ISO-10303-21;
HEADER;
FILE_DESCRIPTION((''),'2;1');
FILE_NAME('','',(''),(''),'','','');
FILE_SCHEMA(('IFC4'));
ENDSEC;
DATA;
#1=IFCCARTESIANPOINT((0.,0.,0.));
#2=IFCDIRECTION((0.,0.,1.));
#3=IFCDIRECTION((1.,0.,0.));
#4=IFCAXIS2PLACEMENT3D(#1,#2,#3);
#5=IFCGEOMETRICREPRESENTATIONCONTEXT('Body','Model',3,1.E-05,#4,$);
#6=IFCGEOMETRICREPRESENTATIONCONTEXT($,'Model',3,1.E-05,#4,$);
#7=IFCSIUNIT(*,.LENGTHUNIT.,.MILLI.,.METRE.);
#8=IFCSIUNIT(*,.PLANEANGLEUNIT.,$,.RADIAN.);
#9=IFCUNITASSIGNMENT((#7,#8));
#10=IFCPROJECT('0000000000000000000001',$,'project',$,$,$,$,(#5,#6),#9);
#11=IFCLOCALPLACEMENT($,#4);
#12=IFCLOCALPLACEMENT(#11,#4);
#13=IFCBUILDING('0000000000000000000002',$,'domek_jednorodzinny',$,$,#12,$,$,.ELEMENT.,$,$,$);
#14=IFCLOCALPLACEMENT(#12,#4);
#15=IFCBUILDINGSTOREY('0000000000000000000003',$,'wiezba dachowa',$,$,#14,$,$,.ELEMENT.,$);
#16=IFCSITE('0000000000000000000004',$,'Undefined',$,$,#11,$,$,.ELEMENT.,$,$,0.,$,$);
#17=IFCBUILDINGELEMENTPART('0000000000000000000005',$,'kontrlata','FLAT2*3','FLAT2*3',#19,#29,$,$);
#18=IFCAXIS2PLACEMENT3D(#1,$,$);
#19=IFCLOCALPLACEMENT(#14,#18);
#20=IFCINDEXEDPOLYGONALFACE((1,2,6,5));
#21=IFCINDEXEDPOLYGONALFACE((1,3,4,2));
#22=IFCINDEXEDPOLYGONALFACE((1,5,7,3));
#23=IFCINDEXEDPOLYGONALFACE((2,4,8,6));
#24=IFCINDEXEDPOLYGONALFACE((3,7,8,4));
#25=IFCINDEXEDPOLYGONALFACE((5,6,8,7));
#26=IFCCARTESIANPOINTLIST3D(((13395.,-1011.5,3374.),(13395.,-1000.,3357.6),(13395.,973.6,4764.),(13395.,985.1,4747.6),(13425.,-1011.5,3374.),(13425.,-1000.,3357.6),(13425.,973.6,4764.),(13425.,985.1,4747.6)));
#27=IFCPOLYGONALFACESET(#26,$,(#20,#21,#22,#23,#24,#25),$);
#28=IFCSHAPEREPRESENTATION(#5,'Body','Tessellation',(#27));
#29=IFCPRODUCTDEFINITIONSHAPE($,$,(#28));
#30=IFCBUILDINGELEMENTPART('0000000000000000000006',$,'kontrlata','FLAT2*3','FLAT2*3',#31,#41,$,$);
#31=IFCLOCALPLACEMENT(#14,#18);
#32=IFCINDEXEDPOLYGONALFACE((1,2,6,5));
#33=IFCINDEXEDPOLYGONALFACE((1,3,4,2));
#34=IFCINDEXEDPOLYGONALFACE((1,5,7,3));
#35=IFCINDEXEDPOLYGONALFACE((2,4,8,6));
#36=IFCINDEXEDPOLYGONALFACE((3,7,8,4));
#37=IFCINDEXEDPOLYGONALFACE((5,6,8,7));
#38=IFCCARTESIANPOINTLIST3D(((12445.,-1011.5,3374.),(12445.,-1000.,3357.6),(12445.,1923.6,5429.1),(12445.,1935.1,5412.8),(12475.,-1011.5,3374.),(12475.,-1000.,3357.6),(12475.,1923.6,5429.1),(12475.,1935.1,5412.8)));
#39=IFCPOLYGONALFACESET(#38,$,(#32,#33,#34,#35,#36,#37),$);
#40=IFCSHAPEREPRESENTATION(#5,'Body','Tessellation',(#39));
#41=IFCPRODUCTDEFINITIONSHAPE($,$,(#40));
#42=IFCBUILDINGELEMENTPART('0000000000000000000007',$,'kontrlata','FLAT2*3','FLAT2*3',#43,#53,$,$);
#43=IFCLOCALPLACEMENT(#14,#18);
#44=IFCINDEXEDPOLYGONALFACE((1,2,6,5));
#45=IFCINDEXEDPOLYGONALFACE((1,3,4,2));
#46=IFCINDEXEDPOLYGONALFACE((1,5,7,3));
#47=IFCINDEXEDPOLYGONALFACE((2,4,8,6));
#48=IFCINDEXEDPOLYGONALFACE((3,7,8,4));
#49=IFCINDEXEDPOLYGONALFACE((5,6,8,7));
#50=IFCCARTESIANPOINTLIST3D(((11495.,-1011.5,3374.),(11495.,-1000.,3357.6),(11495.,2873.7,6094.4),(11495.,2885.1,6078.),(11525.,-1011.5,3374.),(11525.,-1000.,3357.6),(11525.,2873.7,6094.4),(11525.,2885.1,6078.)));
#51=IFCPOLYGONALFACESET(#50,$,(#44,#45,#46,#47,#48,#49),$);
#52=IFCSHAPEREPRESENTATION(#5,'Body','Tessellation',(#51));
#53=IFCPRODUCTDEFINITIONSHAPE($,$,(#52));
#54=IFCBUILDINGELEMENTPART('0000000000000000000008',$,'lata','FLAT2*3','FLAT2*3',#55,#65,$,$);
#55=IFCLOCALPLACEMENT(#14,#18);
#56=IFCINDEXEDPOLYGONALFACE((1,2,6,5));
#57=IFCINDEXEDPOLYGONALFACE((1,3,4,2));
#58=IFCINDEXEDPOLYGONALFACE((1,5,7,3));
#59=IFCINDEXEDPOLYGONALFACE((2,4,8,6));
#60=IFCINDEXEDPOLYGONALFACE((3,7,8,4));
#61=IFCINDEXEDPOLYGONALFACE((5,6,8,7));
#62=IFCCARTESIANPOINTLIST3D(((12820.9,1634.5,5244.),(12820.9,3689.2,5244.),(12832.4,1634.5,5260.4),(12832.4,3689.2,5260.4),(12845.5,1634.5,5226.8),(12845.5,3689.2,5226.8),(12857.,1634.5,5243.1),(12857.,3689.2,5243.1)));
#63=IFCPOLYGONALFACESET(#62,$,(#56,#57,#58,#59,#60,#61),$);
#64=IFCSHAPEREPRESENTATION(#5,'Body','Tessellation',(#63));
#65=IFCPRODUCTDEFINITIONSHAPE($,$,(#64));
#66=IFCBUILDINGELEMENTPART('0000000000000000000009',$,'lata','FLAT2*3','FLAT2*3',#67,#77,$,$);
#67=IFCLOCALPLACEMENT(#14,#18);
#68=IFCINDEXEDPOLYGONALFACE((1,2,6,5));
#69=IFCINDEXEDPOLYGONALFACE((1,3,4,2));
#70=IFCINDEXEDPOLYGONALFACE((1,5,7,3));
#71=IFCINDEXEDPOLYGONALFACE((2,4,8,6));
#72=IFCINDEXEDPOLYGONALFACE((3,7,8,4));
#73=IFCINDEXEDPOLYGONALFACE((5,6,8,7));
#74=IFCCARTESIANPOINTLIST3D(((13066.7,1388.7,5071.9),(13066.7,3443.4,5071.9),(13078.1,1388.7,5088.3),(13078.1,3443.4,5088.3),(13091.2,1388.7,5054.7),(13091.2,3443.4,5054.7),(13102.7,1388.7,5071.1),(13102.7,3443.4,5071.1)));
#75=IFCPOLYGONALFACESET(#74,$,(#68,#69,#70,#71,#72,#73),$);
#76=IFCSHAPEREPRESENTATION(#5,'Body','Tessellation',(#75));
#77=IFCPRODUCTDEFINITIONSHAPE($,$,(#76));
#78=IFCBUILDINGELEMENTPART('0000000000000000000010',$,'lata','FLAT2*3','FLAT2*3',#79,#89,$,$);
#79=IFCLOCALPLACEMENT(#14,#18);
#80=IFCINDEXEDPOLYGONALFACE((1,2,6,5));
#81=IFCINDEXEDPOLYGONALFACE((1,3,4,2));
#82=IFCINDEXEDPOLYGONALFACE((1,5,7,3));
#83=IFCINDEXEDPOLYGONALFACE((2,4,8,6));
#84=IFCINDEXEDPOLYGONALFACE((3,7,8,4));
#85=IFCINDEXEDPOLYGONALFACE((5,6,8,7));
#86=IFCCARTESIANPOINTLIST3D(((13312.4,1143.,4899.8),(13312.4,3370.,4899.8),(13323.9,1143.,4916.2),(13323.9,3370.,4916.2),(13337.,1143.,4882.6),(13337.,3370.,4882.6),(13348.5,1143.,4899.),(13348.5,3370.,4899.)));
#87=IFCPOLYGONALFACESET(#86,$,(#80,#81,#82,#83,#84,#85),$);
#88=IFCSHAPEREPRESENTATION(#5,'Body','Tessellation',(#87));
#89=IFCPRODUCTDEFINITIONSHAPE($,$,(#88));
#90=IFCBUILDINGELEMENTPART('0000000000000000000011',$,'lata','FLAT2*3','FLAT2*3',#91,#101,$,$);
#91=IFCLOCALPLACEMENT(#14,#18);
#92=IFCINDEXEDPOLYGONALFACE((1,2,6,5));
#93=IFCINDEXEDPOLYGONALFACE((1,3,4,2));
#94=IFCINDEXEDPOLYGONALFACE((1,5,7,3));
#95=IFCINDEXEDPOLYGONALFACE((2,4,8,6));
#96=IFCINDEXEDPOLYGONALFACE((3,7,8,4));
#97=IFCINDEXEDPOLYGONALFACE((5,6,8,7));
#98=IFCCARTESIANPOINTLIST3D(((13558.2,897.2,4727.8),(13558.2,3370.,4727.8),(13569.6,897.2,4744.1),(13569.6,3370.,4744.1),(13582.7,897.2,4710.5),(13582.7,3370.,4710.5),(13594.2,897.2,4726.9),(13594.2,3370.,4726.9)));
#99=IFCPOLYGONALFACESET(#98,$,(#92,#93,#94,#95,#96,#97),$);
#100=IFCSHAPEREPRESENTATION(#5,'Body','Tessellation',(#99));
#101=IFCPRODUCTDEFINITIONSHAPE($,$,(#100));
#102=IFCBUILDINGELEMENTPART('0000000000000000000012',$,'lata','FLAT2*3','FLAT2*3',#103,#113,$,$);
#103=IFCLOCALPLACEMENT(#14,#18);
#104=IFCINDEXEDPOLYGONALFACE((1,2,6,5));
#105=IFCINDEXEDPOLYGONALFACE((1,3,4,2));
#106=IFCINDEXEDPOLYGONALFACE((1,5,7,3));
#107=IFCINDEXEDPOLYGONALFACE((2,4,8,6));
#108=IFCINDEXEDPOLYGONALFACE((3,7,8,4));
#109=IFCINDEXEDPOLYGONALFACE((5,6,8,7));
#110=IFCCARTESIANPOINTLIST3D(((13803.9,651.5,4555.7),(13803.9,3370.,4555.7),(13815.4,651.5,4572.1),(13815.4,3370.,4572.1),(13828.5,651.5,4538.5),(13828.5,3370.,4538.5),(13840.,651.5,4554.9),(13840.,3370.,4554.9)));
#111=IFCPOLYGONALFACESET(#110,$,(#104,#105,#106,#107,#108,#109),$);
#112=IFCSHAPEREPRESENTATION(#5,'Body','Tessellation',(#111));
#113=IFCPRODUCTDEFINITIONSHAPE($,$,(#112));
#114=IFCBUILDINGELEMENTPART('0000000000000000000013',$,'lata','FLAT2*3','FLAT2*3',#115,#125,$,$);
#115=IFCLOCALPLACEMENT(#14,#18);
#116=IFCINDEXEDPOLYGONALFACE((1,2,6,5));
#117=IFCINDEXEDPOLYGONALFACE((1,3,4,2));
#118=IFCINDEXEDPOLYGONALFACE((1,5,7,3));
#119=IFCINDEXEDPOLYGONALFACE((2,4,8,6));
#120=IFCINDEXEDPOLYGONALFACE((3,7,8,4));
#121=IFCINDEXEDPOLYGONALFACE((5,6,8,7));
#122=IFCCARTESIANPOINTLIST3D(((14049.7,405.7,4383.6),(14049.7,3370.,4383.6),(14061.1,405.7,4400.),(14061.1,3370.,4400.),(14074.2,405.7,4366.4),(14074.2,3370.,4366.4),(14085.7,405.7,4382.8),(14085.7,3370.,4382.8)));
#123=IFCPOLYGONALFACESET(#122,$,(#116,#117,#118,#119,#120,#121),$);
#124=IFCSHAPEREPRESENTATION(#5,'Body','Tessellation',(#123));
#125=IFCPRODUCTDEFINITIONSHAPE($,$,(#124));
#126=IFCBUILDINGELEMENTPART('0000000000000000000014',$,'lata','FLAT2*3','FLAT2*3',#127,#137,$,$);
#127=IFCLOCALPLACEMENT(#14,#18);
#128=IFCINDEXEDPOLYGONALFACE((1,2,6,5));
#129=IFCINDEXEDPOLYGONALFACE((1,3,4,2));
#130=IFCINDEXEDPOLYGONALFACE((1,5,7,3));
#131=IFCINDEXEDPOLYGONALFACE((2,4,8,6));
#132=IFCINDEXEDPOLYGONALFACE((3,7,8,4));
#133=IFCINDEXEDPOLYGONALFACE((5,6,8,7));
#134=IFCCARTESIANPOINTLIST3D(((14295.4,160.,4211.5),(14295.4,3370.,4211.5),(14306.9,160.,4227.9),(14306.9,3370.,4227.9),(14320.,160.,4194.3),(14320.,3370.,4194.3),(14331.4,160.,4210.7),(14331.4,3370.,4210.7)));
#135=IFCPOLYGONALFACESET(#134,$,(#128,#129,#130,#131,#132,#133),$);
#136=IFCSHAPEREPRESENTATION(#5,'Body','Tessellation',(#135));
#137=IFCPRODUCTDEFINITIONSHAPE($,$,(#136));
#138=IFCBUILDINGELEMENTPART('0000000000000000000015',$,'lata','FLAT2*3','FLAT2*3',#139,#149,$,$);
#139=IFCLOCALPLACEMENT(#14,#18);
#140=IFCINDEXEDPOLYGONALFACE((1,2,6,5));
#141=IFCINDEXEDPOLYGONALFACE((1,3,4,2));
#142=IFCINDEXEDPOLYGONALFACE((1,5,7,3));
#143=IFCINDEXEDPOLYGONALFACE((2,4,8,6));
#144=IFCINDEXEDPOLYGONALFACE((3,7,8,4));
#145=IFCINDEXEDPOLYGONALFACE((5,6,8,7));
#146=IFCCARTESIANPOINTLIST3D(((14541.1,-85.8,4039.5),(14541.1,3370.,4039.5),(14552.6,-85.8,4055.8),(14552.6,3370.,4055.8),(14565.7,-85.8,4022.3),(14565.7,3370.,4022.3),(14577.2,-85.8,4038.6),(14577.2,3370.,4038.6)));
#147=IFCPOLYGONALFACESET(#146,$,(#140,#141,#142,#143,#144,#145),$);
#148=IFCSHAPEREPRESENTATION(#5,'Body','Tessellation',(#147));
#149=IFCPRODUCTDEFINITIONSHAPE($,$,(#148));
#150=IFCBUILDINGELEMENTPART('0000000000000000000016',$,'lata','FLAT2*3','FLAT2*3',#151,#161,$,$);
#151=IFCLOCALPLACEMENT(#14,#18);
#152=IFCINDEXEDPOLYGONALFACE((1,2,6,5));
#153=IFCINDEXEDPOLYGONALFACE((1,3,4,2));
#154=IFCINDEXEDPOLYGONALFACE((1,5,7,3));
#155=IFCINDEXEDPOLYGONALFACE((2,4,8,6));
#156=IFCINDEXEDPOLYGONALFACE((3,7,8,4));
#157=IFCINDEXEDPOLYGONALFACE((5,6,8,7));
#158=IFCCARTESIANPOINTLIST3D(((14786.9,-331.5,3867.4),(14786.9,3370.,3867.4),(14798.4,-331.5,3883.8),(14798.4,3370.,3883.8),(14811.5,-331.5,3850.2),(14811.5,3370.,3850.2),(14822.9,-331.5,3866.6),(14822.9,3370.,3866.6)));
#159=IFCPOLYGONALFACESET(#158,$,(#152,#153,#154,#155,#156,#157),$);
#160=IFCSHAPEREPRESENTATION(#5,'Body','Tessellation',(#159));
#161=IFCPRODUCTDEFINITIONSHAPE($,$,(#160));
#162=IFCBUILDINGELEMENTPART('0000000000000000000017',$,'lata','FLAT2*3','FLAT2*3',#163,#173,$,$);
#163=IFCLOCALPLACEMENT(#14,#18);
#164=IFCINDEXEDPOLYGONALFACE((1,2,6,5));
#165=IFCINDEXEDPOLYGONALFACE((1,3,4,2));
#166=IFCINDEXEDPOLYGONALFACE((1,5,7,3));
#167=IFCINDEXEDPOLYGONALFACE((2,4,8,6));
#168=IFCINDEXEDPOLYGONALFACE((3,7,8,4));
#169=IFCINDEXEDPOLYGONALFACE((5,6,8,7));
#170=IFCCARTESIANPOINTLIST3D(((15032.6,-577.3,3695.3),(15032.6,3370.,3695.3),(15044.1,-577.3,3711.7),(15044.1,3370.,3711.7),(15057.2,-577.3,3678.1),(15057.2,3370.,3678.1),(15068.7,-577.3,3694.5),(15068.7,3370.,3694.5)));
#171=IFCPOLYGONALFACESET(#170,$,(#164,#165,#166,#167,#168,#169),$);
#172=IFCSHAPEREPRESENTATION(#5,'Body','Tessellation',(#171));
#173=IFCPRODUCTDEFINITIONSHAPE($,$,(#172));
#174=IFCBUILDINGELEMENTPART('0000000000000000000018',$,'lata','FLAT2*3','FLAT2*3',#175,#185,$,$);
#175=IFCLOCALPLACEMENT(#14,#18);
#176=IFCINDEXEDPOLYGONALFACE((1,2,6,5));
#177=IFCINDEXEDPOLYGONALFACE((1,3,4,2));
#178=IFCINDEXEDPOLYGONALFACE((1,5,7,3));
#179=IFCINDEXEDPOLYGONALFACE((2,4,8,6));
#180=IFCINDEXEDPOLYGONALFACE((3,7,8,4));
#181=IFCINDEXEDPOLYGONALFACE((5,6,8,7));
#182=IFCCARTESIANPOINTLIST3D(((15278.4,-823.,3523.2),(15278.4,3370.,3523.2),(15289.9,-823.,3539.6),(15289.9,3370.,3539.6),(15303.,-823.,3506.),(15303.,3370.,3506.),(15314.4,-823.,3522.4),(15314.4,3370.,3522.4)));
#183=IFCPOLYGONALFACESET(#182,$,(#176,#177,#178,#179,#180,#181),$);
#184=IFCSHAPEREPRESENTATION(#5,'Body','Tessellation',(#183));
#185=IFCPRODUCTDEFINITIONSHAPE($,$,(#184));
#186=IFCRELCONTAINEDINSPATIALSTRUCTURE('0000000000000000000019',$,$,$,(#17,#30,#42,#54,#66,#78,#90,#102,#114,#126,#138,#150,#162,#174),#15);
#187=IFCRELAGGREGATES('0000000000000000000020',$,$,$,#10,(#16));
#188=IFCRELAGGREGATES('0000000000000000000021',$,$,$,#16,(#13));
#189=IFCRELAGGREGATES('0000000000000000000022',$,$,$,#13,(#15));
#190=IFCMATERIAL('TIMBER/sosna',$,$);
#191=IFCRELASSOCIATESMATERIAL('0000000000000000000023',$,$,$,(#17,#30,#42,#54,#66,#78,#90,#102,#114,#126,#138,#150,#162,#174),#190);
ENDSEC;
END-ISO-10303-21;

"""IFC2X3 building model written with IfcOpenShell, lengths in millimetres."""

from ifc_helpers import new_model, si_unit, frame, origin_with_axes, origin_2d_with_axis, place, context, project, spatial, rectangle, extrude, material, element, save


model = new_model("IFC2X3")

# Units and contexts
model_context_1 = context("Model", 3, precision=1e-05, world=origin_with_axes(), identifier="Body")
model_context_2 = context("Model", 3, precision=1e-05, world=origin_with_axes())
ifc_project = project(units=[si_unit("LENGTHUNIT", "METRE", prefix="MILLI"), si_unit("PLANEANGLEUNIT", "RADIAN")], contexts=[model_context_1, model_context_2])

# Site, building, storey
site_placement = place(None, origin_with_axes())
site = spatial("IfcSite", under=ifc_project, at=site_placement, Name="Undefined", CompositionType="ELEMENT", RefElevation=0.0)
building_placement = place(site_placement, origin_with_axes())
building = spatial("IfcBuilding", under=site, at=building_placement, Name="domek_jednorodzinny", CompositionType="ELEMENT")
storey_placement = place(building_placement, origin_with_axes())
storey = spatial("IfcBuildingStorey", under=building, at=storey_placement, Name="wiezba dachowa", CompositionType="ELEMENT")

# Building element parts
ifc_material = material(Name="TIMBER/sosna")
building_element_part_1_placement = place(storey_placement, frame((13410.0, -1005.7, 3365.8), z_axis=(-1.0, 0.0, 0.0), x_axis=(0.0, 0.819154, 0.573574)))
element("IfcBuildingElementPart", 1, at=building_element_part_1_placement, inside=storey, material=ifc_material, Name="kontrlata", Description="FLAT2*3", ObjectType="FLAT2*3", context=model_context_1, shape_type="SweptSolid", body=[
    extrude(rectangle(XDim=20.0, YDim=30.0, at=origin_2d_with_axis()), frame((2423.3, 0.0, 0.0), z_axis=(-1.0, 0.0, 0.0), x_axis=(0.0, -1.0, 0.0)), (0.0, 0.0, 1.0), 2423.3),
])
building_element_part_2_placement = place(storey_placement, frame((12460.0, -1005.7, 3365.8), z_axis=(-1.0, 0.0, 0.0), x_axis=(0.0, 0.819154, 0.573574)))
element("IfcBuildingElementPart", 2, at=building_element_part_2_placement, inside=storey, material=ifc_material, Name="kontrlata", Description="FLAT2*3", ObjectType="FLAT2*3", context=model_context_1, shape_type="SweptSolid", body=[
    extrude(rectangle(XDim=20.0, YDim=30.0, at=origin_2d_with_axis()), frame((3583.1, 0.0, 0.0), z_axis=(-1.0, 0.0, 0.0), x_axis=(0.0, -1.0, 0.0)), (0.0, 0.0, 1.0), 3583.1),
])
building_element_part_3_placement = place(storey_placement, frame((11510.0, -1005.7, 3365.8), z_axis=(-1.0, 0.0, 0.0), x_axis=(0.0, 0.819154, 0.573574)))
element("IfcBuildingElementPart", 3, at=building_element_part_3_placement, inside=storey, material=ifc_material, Name="kontrlata", Description="FLAT2*3", ObjectType="FLAT2*3", context=model_context_1, shape_type="SweptSolid", body=[
    extrude(rectangle(XDim=20.0, YDim=30.0, at=origin_2d_with_axis()), frame((4742.8, 0.0, 0.0), z_axis=(-1.0, 0.0, 0.0), x_axis=(0.0, -1.0, 0.0)), (0.0, 0.0, 1.0), 4742.8),
])
building_element_part_4_placement = place(storey_placement, frame((12839.0, 1634.5, 5243.6), z_axis=(-0.819152, 0.0, 0.573576), x_axis=(0.0, 1.0, 0.0)))
element("IfcBuildingElementPart", 4, at=building_element_part_4_placement, inside=storey, material=ifc_material, Name="lata", Description="FLAT2*3", ObjectType="FLAT2*3", context=model_context_1, shape_type="SweptSolid", body=[
    extrude(rectangle(XDim=20.0, YDim=30.0, at=origin_2d_with_axis()), frame((2054.7, 0.0, 0.0), z_axis=(-1.0, 0.0, 0.0), x_axis=(0.0, -1.0, 0.0)), (0.0, 0.0, 1.0), 2054.7),
])
building_element_part_5_placement = place(storey_placement, frame((13084.7, 1388.7, 5071.5), z_axis=(-0.819152, 0.0, 0.573576), x_axis=(0.0, 1.0, 0.0)))
element("IfcBuildingElementPart", 5, at=building_element_part_5_placement, inside=storey, material=ifc_material, Name="lata", Description="FLAT2*3", ObjectType="FLAT2*3", context=model_context_1, shape_type="SweptSolid", body=[
    extrude(rectangle(XDim=20.0, YDim=30.0, at=origin_2d_with_axis()), frame((2054.7, 0.0, 0.0), z_axis=(-1.0, 0.0, 0.0), x_axis=(0.0, -1.0, 0.0)), (0.0, 0.0, 1.0), 2054.7),
])
building_element_part_6_placement = place(storey_placement, frame((13330.4, 1143.0, 4899.4), z_axis=(-0.819152, 0.0, 0.573576), x_axis=(0.0, 1.0, 0.0)))
element("IfcBuildingElementPart", 6, at=building_element_part_6_placement, inside=storey, material=ifc_material, Name="lata", Description="FLAT2*3", ObjectType="FLAT2*3", context=model_context_1, shape_type="SweptSolid", body=[
    extrude(rectangle(XDim=20.0, YDim=30.0, at=origin_2d_with_axis()), frame((2227.0, 0.0, 0.0), z_axis=(-1.0, 0.0, 0.0), x_axis=(0.0, -1.0, 0.0)), (0.0, 0.0, 1.0), 2227.0),
])
building_element_part_7_placement = place(storey_placement, frame((13576.2, 897.2, 4727.3), z_axis=(-0.819152, 0.0, 0.573576), x_axis=(0.0, 1.0, 0.0)))
element("IfcBuildingElementPart", 7, at=building_element_part_7_placement, inside=storey, material=ifc_material, Name="lata", Description="FLAT2*3", ObjectType="FLAT2*3", context=model_context_1, shape_type="SweptSolid", body=[
    extrude(rectangle(XDim=20.0, YDim=30.0, at=origin_2d_with_axis()), frame((2472.8, 0.0, 0.0), z_axis=(-1.0, 0.0, 0.0), x_axis=(0.0, -1.0, 0.0)), (0.0, 0.0, 1.0), 2472.8),
])
building_element_part_8_placement = place(storey_placement, frame((13821.9, 651.5, 4555.3), z_axis=(-0.819152, 0.0, 0.573576), x_axis=(0.0, 1.0, 0.0)))
element("IfcBuildingElementPart", 8, at=building_element_part_8_placement, inside=storey, material=ifc_material, Name="lata", Description="FLAT2*3", ObjectType="FLAT2*3", context=model_context_1, shape_type="SweptSolid", body=[
    extrude(rectangle(XDim=20.0, YDim=30.0, at=origin_2d_with_axis()), frame((2718.5, 0.0, 0.0), z_axis=(-1.0, 0.0, 0.0), x_axis=(0.0, -1.0, 0.0)), (0.0, 0.0, 1.0), 2718.5),
])
building_element_part_9_placement = place(storey_placement, frame((14067.7, 405.7, 4383.2), z_axis=(-0.819152, 0.0, 0.573576), x_axis=(0.0, 1.0, 0.0)))
element("IfcBuildingElementPart", 9, at=building_element_part_9_placement, inside=storey, material=ifc_material, Name="lata", Description="FLAT2*3", ObjectType="FLAT2*3", context=model_context_1, shape_type="SweptSolid", body=[
    extrude(rectangle(XDim=20.0, YDim=30.0, at=origin_2d_with_axis()), frame((2964.3, 0.0, 0.0), z_axis=(-1.0, 0.0, 0.0), x_axis=(0.0, -1.0, 0.0)), (0.0, 0.0, 1.0), 2964.3),
])
building_element_part_10_placement = place(storey_placement, frame((14313.4, 160.0, 4211.1), z_axis=(-0.819152, 0.0, 0.573576), x_axis=(0.0, 1.0, 0.0)))
element("IfcBuildingElementPart", 10, at=building_element_part_10_placement, inside=storey, material=ifc_material, Name="lata", Description="FLAT2*3", ObjectType="FLAT2*3", context=model_context_1, shape_type="SweptSolid", body=[
    extrude(rectangle(XDim=20.0, YDim=30.0, at=origin_2d_with_axis()), frame((3210.0, 0.0, 0.0), z_axis=(-1.0, 0.0, 0.0), x_axis=(0.0, -1.0, 0.0)), (0.0, 0.0, 1.0), 3210.0),
])
building_element_part_11_placement = place(storey_placement, frame((14559.2, -85.8, 4039.0), z_axis=(-0.819152, 0.0, 0.573576), x_axis=(0.0, 1.0, 0.0)))
element("IfcBuildingElementPart", 11, at=building_element_part_11_placement, inside=storey, material=ifc_material, Name="lata", Description="FLAT2*3", ObjectType="FLAT2*3", context=model_context_1, shape_type="SweptSolid", body=[
    extrude(rectangle(XDim=20.0, YDim=30.0, at=origin_2d_with_axis()), frame((3455.8, 0.0, 0.0), z_axis=(-1.0, 0.0, 0.0), x_axis=(0.0, -1.0, 0.0)), (0.0, 0.0, 1.0), 3455.8),
])
building_element_part_12_placement = place(storey_placement, frame((14804.9, -331.5, 3867.0), z_axis=(-0.819152, 0.0, 0.573576), x_axis=(0.0, 1.0, 0.0)))
element("IfcBuildingElementPart", 12, at=building_element_part_12_placement, inside=storey, material=ifc_material, Name="lata", Description="FLAT2*3", ObjectType="FLAT2*3", context=model_context_1, shape_type="SweptSolid", body=[
    extrude(rectangle(XDim=20.0, YDim=30.0, at=origin_2d_with_axis()), frame((3701.5, 0.0, 0.0), z_axis=(-1.0, 0.0, 0.0), x_axis=(0.0, -1.0, 0.0)), (0.0, 0.0, 1.0), 3701.5),
])
building_element_part_13_placement = place(storey_placement, frame((15050.7, -577.3, 3694.9), z_axis=(-0.819152, 0.0, 0.573576), x_axis=(0.0, 1.0, 0.0)))
element("IfcBuildingElementPart", 13, at=building_element_part_13_placement, inside=storey, material=ifc_material, Name="lata", Description="FLAT2*3", ObjectType="FLAT2*3", context=model_context_1, shape_type="SweptSolid", body=[
    extrude(rectangle(XDim=20.0, YDim=30.0, at=origin_2d_with_axis()), frame((3947.3, 0.0, 0.0), z_axis=(-1.0, 0.0, 0.0), x_axis=(0.0, -1.0, 0.0)), (0.0, 0.0, 1.0), 3947.3),
])
building_element_part_14_placement = place(storey_placement, frame((15296.4, -823.0, 3522.8), z_axis=(-0.819152, 0.0, 0.573576), x_axis=(0.0, 1.0, 0.0)))
element("IfcBuildingElementPart", 14, at=building_element_part_14_placement, inside=storey, material=ifc_material, Name="lata", Description="FLAT2*3", ObjectType="FLAT2*3", context=model_context_1, shape_type="SweptSolid", body=[
    extrude(rectangle(XDim=20.0, YDim=30.0, at=origin_2d_with_axis()), frame((4193.0, 0.0, 0.0), z_axis=(-1.0, 0.0, 0.0), x_axis=(0.0, -1.0, 0.0)), (0.0, 0.0, 1.0), 4193.0),
])

save(model, "model.ifc")
